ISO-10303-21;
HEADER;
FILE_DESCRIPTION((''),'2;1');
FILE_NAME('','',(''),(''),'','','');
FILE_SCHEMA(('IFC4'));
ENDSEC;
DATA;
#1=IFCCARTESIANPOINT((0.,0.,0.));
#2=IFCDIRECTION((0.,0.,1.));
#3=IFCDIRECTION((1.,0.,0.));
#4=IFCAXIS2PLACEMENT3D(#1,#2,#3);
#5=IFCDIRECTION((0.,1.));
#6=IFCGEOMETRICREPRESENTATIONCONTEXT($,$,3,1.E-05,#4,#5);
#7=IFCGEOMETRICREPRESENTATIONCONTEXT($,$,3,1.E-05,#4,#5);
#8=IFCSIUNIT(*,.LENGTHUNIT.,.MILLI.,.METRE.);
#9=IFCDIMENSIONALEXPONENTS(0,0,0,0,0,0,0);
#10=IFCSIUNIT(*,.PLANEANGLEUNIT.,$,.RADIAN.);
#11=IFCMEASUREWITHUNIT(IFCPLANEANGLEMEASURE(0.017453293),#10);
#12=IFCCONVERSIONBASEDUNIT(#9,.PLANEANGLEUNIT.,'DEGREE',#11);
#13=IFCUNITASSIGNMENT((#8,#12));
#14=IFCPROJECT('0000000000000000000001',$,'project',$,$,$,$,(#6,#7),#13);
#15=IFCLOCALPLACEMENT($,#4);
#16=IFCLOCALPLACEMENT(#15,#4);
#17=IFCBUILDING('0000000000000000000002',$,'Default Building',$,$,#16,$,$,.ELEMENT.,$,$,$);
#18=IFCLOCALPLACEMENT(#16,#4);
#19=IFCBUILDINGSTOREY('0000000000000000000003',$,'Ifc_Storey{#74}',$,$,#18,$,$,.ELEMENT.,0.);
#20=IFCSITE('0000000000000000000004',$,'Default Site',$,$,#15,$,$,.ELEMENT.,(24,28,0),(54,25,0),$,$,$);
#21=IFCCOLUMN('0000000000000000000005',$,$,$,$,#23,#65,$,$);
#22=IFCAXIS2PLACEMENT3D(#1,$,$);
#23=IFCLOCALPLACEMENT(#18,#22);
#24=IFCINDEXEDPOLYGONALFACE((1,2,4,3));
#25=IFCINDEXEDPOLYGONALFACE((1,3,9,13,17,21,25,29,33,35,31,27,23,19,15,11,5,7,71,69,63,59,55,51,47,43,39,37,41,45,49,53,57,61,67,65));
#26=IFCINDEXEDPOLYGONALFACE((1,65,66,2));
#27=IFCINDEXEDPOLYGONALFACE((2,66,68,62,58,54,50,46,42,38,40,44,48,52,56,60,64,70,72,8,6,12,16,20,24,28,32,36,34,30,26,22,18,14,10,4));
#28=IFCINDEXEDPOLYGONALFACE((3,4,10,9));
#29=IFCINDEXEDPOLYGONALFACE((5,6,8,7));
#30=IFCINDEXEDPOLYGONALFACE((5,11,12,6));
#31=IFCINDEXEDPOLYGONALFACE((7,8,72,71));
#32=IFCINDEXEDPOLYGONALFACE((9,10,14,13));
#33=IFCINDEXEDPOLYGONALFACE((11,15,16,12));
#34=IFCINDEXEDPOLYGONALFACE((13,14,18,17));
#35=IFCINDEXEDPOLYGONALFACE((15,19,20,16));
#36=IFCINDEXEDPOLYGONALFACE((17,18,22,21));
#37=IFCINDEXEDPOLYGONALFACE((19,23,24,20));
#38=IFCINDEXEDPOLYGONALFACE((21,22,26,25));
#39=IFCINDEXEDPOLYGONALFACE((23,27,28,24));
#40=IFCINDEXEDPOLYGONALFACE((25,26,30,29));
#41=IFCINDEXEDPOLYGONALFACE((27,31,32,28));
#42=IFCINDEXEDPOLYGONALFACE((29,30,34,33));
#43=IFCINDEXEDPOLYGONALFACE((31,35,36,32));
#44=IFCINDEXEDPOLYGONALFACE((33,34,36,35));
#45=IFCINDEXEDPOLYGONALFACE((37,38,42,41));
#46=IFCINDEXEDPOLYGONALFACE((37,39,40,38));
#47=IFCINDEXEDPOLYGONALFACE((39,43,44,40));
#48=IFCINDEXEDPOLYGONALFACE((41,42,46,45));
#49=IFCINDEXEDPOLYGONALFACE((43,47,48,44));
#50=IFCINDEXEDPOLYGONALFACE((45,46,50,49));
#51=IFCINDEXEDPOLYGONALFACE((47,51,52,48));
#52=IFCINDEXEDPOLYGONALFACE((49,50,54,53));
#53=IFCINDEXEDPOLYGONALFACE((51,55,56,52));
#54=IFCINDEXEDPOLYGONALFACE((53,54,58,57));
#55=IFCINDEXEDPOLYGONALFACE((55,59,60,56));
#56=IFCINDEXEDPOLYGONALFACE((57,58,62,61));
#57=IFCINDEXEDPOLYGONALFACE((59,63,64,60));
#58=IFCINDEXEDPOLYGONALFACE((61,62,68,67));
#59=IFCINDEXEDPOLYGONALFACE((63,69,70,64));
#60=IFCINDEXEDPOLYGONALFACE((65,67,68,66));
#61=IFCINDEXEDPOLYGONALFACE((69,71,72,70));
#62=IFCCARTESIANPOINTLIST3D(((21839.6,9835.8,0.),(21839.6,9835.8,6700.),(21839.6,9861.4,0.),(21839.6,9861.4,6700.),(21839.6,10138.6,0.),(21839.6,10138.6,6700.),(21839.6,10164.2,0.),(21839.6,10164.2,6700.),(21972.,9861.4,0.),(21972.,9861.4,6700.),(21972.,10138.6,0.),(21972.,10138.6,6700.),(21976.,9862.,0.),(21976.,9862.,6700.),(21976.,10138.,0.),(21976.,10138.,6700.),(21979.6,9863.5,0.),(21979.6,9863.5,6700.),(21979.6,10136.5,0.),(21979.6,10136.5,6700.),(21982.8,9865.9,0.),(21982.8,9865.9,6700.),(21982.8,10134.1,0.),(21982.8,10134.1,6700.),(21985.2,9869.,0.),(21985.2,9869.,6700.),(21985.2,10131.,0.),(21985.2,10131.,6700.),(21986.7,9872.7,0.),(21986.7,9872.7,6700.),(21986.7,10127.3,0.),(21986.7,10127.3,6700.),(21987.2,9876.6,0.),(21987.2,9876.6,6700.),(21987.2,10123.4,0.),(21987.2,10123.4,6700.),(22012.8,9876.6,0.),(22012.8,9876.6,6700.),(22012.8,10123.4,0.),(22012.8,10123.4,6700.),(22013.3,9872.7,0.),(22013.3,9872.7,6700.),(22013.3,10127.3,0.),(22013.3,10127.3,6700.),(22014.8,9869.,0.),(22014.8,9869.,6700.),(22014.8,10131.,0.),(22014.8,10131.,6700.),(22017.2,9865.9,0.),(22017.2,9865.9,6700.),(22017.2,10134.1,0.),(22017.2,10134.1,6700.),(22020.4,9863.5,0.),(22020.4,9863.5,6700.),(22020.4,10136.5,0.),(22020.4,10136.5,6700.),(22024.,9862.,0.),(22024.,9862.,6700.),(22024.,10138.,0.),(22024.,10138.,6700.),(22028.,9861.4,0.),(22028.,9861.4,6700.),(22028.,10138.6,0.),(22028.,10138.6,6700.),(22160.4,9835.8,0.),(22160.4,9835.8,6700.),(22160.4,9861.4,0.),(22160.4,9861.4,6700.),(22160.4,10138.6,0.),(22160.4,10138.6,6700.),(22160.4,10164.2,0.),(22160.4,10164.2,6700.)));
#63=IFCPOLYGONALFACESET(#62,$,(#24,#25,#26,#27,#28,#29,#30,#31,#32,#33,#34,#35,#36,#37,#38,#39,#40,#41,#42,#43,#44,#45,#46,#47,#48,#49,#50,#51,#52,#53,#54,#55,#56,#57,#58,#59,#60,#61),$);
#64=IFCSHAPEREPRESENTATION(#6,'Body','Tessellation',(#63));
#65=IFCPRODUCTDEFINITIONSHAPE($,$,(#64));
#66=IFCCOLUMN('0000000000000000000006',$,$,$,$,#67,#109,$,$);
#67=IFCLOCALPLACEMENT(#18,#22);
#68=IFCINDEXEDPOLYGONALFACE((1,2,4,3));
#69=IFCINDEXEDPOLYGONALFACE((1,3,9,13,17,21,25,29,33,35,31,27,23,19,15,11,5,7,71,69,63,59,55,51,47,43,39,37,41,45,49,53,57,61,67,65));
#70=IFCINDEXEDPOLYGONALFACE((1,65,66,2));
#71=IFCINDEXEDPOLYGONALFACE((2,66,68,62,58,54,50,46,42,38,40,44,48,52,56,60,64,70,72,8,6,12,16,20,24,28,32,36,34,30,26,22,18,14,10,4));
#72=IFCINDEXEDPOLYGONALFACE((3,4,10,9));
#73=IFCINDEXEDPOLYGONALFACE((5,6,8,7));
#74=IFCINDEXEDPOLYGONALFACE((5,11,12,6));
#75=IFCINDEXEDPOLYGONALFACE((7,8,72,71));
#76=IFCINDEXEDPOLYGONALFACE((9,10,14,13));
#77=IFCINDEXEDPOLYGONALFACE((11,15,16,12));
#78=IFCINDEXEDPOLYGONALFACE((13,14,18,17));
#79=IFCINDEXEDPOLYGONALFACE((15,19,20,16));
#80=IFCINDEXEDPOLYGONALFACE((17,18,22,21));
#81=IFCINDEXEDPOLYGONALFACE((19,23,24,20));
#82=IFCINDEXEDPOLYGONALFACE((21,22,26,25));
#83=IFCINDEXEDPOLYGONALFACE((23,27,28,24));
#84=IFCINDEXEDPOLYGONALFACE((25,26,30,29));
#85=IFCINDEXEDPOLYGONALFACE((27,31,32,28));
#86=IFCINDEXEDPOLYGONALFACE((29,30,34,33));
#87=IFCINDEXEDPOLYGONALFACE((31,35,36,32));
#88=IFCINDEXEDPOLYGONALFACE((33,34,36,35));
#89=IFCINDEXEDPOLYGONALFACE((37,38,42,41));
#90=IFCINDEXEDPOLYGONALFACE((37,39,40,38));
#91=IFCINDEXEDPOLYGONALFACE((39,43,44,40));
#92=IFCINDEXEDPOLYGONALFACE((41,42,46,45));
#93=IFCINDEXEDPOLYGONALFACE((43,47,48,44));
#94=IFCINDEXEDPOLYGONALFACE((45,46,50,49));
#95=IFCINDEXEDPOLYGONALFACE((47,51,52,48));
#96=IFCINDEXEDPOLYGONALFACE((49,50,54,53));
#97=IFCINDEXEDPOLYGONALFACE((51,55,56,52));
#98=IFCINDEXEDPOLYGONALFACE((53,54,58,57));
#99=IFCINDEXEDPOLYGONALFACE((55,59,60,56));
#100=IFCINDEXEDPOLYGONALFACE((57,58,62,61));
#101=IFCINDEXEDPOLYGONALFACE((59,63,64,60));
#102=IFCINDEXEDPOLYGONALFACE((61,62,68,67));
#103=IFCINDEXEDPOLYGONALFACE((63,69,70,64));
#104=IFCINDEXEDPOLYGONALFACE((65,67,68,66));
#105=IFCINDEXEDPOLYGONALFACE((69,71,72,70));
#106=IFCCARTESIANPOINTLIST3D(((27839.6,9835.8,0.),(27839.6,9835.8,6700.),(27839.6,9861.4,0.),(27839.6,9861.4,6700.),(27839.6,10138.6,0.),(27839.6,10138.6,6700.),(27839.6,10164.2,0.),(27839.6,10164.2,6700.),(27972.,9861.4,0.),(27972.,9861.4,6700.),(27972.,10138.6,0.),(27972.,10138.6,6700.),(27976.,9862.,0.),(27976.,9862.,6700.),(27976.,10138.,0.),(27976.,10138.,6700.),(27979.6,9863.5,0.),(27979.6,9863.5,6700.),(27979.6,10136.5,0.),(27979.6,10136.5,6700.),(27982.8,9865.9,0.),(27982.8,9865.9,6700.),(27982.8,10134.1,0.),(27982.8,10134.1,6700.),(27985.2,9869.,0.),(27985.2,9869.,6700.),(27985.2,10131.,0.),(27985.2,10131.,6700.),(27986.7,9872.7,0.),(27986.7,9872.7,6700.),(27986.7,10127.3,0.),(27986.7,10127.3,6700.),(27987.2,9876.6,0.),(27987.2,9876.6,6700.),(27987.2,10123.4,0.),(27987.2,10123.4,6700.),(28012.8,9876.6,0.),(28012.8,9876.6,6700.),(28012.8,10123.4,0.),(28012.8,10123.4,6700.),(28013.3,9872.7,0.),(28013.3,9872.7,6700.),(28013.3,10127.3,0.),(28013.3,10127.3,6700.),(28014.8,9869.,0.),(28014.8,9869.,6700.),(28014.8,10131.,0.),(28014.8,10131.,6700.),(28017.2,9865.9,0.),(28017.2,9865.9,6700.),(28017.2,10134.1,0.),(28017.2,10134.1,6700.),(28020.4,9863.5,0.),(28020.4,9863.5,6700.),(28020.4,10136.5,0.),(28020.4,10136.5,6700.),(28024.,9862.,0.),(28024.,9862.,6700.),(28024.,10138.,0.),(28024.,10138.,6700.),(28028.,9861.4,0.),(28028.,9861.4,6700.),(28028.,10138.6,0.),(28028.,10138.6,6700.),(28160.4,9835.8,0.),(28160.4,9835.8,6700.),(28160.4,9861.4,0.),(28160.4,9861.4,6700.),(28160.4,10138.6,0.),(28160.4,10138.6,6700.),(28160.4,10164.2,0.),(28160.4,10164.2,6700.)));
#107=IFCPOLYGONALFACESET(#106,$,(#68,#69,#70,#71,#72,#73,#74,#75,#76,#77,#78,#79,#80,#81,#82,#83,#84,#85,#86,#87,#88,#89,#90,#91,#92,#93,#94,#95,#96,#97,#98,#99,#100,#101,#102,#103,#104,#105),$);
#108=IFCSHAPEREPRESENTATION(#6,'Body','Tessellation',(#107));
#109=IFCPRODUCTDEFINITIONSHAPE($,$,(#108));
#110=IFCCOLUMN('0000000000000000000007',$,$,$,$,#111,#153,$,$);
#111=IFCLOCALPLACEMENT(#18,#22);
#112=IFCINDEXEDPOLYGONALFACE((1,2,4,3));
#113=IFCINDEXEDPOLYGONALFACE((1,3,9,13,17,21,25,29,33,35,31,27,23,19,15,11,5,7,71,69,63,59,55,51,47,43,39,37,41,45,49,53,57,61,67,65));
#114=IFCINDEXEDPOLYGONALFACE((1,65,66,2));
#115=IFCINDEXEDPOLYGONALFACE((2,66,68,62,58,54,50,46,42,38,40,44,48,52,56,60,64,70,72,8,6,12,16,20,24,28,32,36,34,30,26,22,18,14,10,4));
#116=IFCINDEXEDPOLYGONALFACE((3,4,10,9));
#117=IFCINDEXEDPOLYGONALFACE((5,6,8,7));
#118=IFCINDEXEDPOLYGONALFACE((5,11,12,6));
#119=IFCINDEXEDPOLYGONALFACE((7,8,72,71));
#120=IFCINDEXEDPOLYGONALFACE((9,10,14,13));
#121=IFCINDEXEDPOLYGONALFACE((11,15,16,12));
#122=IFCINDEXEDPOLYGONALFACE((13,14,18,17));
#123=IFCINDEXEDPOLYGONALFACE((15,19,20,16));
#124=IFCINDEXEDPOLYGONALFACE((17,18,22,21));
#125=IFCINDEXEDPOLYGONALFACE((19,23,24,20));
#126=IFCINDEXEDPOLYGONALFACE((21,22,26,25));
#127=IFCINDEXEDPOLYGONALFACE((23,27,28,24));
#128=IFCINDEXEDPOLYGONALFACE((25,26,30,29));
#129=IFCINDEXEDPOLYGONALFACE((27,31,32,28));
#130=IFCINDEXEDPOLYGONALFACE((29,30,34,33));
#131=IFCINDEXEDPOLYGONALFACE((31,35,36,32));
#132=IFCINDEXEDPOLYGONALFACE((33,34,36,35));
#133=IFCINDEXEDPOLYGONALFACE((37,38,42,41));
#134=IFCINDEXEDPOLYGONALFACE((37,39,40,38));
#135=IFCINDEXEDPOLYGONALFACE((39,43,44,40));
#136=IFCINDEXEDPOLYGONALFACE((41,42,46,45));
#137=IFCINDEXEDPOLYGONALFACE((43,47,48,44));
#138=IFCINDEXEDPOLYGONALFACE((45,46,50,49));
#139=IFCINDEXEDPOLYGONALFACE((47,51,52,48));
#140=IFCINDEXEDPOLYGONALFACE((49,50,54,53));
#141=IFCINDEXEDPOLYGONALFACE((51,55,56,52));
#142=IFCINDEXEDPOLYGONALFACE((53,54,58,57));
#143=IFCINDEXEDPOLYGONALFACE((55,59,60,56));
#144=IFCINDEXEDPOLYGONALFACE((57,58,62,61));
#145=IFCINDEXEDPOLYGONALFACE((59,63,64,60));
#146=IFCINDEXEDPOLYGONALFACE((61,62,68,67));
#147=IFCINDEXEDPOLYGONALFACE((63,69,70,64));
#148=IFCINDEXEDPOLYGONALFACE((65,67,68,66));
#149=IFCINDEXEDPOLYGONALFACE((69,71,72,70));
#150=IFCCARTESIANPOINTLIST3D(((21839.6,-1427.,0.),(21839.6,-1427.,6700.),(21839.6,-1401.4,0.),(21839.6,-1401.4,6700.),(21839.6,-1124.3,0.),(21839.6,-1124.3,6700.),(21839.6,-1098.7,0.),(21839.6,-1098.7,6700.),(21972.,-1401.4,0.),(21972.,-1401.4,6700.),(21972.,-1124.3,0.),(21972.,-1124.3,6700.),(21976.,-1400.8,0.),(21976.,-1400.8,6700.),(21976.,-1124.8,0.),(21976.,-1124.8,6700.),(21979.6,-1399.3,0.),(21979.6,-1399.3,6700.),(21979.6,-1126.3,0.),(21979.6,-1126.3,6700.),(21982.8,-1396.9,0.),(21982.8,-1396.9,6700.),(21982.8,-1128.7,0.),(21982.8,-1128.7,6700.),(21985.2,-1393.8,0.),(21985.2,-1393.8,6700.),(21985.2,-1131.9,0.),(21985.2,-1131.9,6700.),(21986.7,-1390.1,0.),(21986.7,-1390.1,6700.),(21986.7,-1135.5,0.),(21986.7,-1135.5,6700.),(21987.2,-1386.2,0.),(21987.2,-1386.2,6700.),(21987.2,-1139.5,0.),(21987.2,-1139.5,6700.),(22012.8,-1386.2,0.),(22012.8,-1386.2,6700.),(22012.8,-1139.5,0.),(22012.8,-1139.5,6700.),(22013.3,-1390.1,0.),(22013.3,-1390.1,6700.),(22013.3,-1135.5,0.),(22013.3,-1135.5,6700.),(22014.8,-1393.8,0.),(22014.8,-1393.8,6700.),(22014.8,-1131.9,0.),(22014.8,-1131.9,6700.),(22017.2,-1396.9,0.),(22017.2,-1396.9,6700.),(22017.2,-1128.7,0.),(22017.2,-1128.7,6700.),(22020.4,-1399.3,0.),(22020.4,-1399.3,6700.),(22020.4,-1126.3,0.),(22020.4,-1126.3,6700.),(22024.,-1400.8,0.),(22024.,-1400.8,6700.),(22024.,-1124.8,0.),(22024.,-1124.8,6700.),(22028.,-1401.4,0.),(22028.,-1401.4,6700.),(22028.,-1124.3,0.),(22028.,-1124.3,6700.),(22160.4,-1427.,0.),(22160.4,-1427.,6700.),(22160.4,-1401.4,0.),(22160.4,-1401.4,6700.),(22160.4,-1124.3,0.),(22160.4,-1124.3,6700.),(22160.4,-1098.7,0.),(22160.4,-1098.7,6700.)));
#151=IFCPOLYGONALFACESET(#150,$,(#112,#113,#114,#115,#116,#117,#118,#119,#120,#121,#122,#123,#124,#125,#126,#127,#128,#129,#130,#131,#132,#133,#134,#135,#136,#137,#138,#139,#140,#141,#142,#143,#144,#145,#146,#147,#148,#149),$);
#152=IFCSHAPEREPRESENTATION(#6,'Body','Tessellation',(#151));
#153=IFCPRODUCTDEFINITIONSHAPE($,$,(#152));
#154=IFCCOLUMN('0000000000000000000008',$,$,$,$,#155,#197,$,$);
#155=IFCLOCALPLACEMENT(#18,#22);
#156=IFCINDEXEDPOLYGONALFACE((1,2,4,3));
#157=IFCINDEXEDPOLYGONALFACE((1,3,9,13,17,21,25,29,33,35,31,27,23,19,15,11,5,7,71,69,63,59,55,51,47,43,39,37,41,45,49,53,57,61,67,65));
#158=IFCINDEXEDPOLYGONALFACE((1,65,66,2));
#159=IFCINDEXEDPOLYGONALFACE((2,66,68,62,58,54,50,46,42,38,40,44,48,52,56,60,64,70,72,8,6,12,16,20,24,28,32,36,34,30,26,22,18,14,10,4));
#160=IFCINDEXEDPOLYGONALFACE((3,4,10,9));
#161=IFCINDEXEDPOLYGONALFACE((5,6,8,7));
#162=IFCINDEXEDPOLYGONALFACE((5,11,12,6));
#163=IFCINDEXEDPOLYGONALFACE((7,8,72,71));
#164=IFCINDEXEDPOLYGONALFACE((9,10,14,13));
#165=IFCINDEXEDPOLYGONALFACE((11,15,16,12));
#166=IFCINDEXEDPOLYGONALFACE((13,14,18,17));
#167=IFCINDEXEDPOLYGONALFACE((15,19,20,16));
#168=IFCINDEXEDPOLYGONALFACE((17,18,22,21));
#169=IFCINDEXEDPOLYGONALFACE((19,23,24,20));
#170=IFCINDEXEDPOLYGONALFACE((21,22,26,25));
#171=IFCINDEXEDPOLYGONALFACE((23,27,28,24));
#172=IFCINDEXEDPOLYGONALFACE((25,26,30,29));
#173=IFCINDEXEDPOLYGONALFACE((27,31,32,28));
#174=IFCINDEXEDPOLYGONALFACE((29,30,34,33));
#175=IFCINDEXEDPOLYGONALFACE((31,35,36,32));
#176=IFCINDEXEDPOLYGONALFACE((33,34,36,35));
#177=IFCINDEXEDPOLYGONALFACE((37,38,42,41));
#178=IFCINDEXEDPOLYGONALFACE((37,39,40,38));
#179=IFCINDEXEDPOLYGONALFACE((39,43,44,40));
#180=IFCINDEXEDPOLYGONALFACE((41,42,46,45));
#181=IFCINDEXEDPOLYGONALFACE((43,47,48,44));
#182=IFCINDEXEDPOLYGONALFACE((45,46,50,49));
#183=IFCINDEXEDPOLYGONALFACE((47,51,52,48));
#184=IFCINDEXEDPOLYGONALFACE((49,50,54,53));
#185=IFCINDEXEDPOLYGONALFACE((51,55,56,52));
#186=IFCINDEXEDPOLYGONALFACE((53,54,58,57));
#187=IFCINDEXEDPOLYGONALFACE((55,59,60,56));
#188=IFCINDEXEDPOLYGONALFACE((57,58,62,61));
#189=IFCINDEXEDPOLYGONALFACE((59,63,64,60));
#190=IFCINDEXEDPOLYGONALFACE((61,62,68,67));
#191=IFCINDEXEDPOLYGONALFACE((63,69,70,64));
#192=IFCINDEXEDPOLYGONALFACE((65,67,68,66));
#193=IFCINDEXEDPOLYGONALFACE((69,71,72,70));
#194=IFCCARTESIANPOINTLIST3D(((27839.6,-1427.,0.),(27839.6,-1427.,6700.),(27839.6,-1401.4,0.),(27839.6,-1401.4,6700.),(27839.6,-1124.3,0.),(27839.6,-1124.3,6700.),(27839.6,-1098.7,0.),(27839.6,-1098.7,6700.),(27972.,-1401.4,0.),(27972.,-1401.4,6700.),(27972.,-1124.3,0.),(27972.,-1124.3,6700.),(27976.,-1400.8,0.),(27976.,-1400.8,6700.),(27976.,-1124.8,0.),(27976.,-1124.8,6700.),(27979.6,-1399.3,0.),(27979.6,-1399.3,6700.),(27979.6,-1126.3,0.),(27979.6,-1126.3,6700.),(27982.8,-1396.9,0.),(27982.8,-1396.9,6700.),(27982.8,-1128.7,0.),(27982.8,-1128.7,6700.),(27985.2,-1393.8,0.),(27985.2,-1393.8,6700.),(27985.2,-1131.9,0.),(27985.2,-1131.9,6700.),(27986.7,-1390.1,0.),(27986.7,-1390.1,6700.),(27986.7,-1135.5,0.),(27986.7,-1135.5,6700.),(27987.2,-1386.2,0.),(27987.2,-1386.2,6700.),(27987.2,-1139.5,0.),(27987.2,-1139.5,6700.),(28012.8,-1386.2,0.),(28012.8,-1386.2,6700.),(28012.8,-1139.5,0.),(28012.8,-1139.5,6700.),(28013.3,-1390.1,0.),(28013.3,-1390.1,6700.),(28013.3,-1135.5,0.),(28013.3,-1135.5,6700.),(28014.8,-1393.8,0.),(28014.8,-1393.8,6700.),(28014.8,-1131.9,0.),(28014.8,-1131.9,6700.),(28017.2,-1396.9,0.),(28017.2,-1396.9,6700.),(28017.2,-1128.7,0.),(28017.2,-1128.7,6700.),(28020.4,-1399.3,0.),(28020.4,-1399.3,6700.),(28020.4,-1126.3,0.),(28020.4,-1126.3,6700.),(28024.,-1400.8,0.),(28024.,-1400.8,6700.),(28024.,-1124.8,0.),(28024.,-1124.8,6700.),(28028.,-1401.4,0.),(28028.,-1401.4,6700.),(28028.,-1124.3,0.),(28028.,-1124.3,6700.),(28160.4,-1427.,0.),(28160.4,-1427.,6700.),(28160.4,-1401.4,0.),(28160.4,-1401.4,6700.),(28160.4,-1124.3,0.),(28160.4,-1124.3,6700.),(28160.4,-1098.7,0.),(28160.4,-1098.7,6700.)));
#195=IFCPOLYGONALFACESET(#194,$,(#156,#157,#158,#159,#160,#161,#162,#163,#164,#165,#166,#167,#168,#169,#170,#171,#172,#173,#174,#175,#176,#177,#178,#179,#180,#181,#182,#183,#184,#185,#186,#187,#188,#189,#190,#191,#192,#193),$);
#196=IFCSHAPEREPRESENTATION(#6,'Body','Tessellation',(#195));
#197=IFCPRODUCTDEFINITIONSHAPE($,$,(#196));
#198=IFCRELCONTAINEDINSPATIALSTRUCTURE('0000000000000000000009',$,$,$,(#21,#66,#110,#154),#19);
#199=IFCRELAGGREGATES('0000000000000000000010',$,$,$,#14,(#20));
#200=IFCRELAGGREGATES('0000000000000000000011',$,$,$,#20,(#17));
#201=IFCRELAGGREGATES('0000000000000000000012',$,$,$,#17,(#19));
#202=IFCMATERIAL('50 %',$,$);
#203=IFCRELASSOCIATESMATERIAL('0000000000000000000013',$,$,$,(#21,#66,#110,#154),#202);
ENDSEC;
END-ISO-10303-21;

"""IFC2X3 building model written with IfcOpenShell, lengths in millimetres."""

from ifc_helpers import new_model, entity, si_unit, converted_unit, direction, frame, origin_with_axes, origin_2d_with_axis, place, context, project, spatial, i_section, extrude, material, element, save


model = new_model("IFC2X3")

# Units and contexts
context_of_model_1 = context(None, 3, precision=1e-05, world=origin_with_axes(), true_north=direction((0.0, 1.0)))
context_of_model_2 = context(None, 3, precision=1e-05, world=origin_with_axes(), true_north=direction((0.0, 1.0)))
ifc_project = project(units=[si_unit("LENGTHUNIT", "METRE", prefix="MILLI"), converted_unit("PLANEANGLEUNIT", "DEGREE", entity("IfcPlaneAngleMeasure", 0.017453293), si_unit("PLANEANGLEUNIT", "RADIAN"), dimensions=[0, 0, 0, 0, 0, 0, 0])], contexts=[context_of_model_1, context_of_model_2])

# Site, building, storey
site_placement = place(None, origin_with_axes())
site = spatial("IfcSite", under=ifc_project, at=site_placement, Name="Default Site", CompositionType="ELEMENT", RefLatitude=(24, 28, 0), RefLongitude=(54, 25, 0))
building_placement = place(site_placement, origin_with_axes())
building = spatial("IfcBuilding", under=site, at=building_placement, Name="Default Building", CompositionType="ELEMENT")
storey_placement = place(building_placement, origin_with_axes())
storey = spatial("IfcBuildingStorey", under=building, at=storey_placement, Name="Ifc_Storey{#74}", CompositionType="ELEMENT", Elevation=0.0)

# Columns
ifc_material_1 = material(Name="50 %")
for number, where, z_axis, x_axis in (
    (1, (22000.0, 10000.0, 0.0), (0.0, 0.0, 1.0), (1.0, 0.0, 0.0)),
    (2, (28000.0, 10000.0, 0.0), (0.0, 0.0, 1.0), (1.0, 0.0, 0.0)),
):
    element("IfcColumn", number, at=place(storey_placement, frame(where, z_axis=z_axis, x_axis=x_axis)), inside=storey, material=ifc_material_1, context=context_of_model_1, shape_type="SweptSolid", body=[
        extrude(i_section(OverallWidth=320.9, OverallDepth=328.3, WebThickness=25.5, FlangeThickness=25.6, FilletRadius=15.2, at=origin_2d_with_axis()), origin_with_axes(), (0.0, 0.0, 1.0), 6700.0),
    ])
for number, where, z_axis, x_axis in (
    (3, (22000.0, -1262.8, 0.0), (0.0, 0.0, 1.0), (-1.0, 0.0, 0.0)),
    (4, (28000.0, -1262.8, 0.0), (0.0, 0.0, 1.0), (-1.0, 0.0, 0.0)),
):
    element("IfcColumn", number, at=place(storey_placement, frame(where, z_axis=z_axis, x_axis=x_axis)), inside=storey, material=ifc_material_1, context=context_of_model_1, shape_type="SweptSolid", body=[
        extrude(i_section(OverallWidth=320.9, OverallDepth=328.3, WebThickness=25.5, FlangeThickness=25.6, FilletRadius=15.2, at=origin_2d_with_axis()), frame((0.0, 0.0, 0.0), z_axis=(0.0, 0.0, 1.0), x_axis=(-1.0, 0.0, 0.0)), (0.0, 0.0, 1.0), 6700.0),
    ])

save(model, "model.ifc")
